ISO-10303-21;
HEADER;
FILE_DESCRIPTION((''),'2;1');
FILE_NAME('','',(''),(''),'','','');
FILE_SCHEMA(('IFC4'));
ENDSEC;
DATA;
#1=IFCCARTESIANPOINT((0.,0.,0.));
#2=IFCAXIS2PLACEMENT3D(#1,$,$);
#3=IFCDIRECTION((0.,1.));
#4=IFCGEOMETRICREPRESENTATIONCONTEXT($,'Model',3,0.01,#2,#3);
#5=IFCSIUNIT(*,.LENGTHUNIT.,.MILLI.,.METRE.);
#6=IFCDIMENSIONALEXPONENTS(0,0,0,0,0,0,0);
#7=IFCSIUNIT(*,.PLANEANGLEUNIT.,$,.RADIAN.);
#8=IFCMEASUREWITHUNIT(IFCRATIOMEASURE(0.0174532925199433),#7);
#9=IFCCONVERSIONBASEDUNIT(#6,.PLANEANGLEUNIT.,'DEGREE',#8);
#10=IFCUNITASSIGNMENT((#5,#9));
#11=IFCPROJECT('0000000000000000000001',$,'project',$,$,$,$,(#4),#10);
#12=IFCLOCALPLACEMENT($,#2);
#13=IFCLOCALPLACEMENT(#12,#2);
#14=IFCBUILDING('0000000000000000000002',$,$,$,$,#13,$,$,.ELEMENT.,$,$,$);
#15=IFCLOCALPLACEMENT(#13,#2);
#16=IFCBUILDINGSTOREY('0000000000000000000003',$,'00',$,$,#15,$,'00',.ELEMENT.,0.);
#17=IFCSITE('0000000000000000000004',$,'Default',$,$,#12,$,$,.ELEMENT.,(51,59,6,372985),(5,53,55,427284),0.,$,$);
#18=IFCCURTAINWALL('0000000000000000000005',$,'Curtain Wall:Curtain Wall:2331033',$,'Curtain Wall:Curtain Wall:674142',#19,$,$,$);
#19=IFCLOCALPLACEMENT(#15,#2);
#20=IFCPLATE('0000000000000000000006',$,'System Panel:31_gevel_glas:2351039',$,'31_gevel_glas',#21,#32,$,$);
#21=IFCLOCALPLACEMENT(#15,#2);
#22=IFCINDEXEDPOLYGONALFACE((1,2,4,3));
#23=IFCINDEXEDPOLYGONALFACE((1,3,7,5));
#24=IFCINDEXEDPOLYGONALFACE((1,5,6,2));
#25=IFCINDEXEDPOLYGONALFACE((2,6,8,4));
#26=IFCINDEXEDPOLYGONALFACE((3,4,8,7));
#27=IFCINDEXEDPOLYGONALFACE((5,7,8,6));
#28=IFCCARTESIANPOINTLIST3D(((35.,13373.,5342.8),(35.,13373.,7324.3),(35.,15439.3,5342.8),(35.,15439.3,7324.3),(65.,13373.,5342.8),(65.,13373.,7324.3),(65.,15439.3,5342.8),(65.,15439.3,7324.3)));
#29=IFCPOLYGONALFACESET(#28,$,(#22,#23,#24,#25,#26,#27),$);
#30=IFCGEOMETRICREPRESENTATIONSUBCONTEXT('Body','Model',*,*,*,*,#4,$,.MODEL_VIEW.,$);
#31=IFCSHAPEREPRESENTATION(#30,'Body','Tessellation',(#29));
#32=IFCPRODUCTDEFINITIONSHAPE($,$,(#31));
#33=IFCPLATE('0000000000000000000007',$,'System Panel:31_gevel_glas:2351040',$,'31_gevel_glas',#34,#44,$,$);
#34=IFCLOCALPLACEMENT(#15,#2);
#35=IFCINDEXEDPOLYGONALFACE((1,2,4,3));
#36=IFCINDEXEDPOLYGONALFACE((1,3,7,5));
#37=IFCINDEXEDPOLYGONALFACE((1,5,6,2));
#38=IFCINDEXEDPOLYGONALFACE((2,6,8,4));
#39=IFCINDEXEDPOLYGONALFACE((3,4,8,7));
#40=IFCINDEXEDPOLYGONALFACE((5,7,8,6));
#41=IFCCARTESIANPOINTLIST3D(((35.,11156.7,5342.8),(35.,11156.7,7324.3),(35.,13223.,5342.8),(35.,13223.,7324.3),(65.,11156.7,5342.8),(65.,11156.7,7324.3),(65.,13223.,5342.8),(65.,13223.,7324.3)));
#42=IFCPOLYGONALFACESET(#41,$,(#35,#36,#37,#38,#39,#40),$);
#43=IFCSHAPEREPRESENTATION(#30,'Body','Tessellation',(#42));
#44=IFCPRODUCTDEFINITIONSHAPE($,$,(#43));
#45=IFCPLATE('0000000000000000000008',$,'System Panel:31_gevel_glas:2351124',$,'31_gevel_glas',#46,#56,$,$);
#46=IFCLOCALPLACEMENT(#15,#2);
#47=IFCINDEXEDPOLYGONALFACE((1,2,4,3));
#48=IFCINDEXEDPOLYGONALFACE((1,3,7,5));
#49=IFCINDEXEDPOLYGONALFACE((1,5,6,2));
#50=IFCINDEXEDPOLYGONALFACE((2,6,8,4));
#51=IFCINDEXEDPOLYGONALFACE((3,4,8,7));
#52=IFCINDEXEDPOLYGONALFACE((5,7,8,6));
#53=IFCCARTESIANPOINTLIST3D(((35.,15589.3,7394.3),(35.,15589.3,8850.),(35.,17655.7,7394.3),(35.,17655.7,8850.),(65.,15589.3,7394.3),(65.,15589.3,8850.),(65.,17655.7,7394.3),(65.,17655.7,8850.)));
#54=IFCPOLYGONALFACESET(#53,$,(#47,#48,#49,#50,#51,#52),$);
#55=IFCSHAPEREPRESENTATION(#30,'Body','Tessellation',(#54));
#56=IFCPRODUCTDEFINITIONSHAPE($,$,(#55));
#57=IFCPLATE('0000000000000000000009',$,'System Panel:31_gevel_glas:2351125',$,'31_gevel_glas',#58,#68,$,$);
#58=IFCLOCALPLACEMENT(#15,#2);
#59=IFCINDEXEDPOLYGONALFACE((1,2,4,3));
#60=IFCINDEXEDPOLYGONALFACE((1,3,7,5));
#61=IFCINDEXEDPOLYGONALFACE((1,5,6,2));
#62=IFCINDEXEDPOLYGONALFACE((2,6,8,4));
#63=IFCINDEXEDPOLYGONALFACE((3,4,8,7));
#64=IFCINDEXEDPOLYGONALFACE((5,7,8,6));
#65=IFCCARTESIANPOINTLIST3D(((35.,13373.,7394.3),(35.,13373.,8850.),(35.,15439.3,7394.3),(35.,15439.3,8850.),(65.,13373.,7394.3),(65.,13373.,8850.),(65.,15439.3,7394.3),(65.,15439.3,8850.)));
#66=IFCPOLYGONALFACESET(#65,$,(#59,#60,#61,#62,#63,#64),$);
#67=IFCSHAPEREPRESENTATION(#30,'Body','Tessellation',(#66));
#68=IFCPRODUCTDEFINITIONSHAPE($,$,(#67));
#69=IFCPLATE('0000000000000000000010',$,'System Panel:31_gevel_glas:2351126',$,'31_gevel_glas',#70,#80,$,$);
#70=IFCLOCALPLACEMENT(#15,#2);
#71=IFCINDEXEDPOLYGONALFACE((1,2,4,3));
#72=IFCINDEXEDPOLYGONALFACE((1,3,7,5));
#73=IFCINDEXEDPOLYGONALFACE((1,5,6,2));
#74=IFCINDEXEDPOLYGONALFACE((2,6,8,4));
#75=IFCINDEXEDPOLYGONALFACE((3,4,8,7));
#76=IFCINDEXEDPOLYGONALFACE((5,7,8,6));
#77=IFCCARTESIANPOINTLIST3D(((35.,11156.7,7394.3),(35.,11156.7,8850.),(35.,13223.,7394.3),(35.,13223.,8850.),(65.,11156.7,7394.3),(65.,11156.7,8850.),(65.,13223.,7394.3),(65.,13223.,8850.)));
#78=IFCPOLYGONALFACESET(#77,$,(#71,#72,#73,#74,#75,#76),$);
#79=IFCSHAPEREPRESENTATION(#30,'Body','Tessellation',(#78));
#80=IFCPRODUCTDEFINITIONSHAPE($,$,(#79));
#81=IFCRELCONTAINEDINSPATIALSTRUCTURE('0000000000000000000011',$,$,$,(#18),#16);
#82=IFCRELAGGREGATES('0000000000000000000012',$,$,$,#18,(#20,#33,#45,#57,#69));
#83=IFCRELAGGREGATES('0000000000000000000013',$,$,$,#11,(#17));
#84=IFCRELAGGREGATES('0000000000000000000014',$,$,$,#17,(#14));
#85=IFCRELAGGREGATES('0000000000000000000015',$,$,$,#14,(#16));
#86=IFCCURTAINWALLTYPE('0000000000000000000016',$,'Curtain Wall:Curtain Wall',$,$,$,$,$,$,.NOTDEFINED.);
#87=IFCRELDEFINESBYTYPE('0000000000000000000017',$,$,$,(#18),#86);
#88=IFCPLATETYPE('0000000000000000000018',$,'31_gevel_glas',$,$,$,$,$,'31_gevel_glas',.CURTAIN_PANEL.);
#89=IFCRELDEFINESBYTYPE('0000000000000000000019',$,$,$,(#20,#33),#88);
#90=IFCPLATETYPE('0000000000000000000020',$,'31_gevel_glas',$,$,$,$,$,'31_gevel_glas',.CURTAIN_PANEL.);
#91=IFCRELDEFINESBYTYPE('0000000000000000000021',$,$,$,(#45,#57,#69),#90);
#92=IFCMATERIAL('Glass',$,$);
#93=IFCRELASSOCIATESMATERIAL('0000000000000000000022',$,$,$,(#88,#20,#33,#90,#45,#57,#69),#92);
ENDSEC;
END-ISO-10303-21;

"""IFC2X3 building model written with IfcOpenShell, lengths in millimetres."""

from ifc_helpers import new_model, entity, si_unit, converted_unit, direction, frame, origin, origin_2d_with_axis, place, context, subcontext, project, spatial, rectangle, extrude, source, transform, mapped, material, type_object, type_shapes, element, aggregate, save


model = new_model("IFC2X3")

# Units and contexts
model_context = context("Model", 3, precision=0.01, world=origin(), true_north=direction((0.0, 1.0)))
body_context = subcontext(model_context, "Body", "Model", "MODEL_VIEW")
ifc_project = project(units=[si_unit("LENGTHUNIT", "METRE", prefix="MILLI"), converted_unit("PLANEANGLEUNIT", "DEGREE", entity("IfcRatioMeasure", 0.0174532925199433), si_unit("PLANEANGLEUNIT", "RADIAN"), dimensions=[0, 0, 0, 0, 0, 0, 0])], contexts=[model_context])

# Site, building, storey
site_placement = place(None, origin())
site = spatial("IfcSite", under=ifc_project, at=site_placement, Name="Default", CompositionType="ELEMENT", RefLatitude=(51, 59, 6, 372985), RefLongitude=(5, 53, 55, 427284), RefElevation=0.0)
building_placement = place(site_placement, origin())
building = spatial("IfcBuilding", under=site, at=building_placement, CompositionType="ELEMENT")
storey_placement = place(building_placement, origin())
storey = spatial("IfcBuildingStorey", under=building, at=storey_placement, Name="00", LongName="00", CompositionType="ELEMENT", Elevation=0.0)

# Curtain wall, plates
curtain_wall_type = type_object("IfcCurtainWallType", Name="Curtain Wall:Curtain Wall", PredefinedType="NOTDEFINED")
curtain_wall_placement = place(storey_placement, origin())
curtain_wall = element("IfcCurtainWall", 1, at=curtain_wall_placement, inside=storey, type_object=curtain_wall_type, Name="Curtain Wall:Curtain Wall:2331033", ObjectType="Curtain Wall:Curtain Wall:674142")
ifc_material_1 = material(Name="Glass")
plate_type_1 = type_object("IfcPlateType", Name="31_gevel_glas", ElementType="31_gevel_glas", PredefinedType="CURTAIN_PANEL", material=ifc_material_1)
shared_shape_1 = source(origin(), body_context, "Body", "SweptSolid", [
    extrude(rectangle(XDim=30.0, YDim=2066.3, at=origin_2d_with_axis()), frame((0.0, 50.0, 0.0), z_axis=(0.0, 0.0, 1.0), x_axis=(0.0, 1.0, 0.0)), (0.0, 0.0, 1.0), 1981.5),
])
type_shapes(plate_type_1, [shared_shape_1])
plate_1_placement = place(curtain_wall_placement, frame((0.0, 14406.2, 5342.8), z_axis=(0.0, 0.0, 1.0), x_axis=(0.0, -1.0, 0.0)))
plate_1 = element("IfcPlate", 2, at=plate_1_placement, type_object=plate_type_1, material=ifc_material_1, Name="System Panel:31_gevel_glas:2351039", ObjectType="31_gevel_glas", context=body_context, shape_type="MappedRepresentation", body=[
    mapped(shared_shape_1, transform((0.0, 0.0, 0.0), scale=1.0)),
])
plate_2_placement = place(curtain_wall_placement, frame((0.0, 12189.8, 5342.8), z_axis=(0.0, 0.0, 1.0), x_axis=(0.0, -1.0, 0.0)))
plate_2 = element("IfcPlate", 3, at=plate_2_placement, type_object=plate_type_1, material=ifc_material_1, Name="System Panel:31_gevel_glas:2351040", ObjectType="31_gevel_glas", context=body_context, shape_type="MappedRepresentation", body=[
    mapped(shared_shape_1, transform((0.0, 0.0, 0.0), scale=1.0)),
])
plate_type_2 = type_object("IfcPlateType", Name="31_gevel_glas", ElementType="31_gevel_glas", PredefinedType="CURTAIN_PANEL", material=ifc_material_1)
shared_shape_2 = source(origin(), body_context, "Body", "SweptSolid", [
    extrude(rectangle(XDim=30.0, YDim=2066.3, at=origin_2d_with_axis()), frame((0.0, 50.0, 0.0), z_axis=(0.0, 0.0, 1.0), x_axis=(0.0, 1.0, 0.0)), (0.0, 0.0, 1.0), 1455.7),
])
type_shapes(plate_type_2, [shared_shape_2])
plate_3_placement = place(curtain_wall_placement, frame((0.0, 16622.5, 7394.3), z_axis=(0.0, 0.0, 1.0), x_axis=(0.0, -1.0, 0.0)))
plate_3 = element("IfcPlate", 4, at=plate_3_placement, type_object=plate_type_2, material=ifc_material_1, Name="System Panel:31_gevel_glas:2351124", ObjectType="31_gevel_glas", context=body_context, shape_type="MappedRepresentation", body=[
    mapped(shared_shape_2, transform((0.0, 0.0, 0.0), scale=1.0)),
])
plate_4_placement = place(curtain_wall_placement, frame((0.0, 14406.2, 7394.3), z_axis=(0.0, 0.0, 1.0), x_axis=(0.0, -1.0, 0.0)))
plate_4 = element("IfcPlate", 5, at=plate_4_placement, type_object=plate_type_2, material=ifc_material_1, Name="System Panel:31_gevel_glas:2351125", ObjectType="31_gevel_glas", context=body_context, shape_type="MappedRepresentation", body=[
    mapped(shared_shape_2, transform((0.0, 0.0, 0.0), scale=1.0)),
])
plate_5_placement = place(curtain_wall_placement, frame((0.0, 12189.8, 7394.3), z_axis=(0.0, 0.0, 1.0), x_axis=(0.0, -1.0, 0.0)))
plate_5 = element("IfcPlate", 6, at=plate_5_placement, type_object=plate_type_2, material=ifc_material_1, Name="System Panel:31_gevel_glas:2351126", ObjectType="31_gevel_glas", context=body_context, shape_type="MappedRepresentation", body=[
    mapped(shared_shape_2, transform((0.0, 0.0, 0.0), scale=1.0)),
])
aggregate(curtain_wall, [plate_1, plate_2, plate_3, plate_4, plate_5])

save(model, "model.ifc")
